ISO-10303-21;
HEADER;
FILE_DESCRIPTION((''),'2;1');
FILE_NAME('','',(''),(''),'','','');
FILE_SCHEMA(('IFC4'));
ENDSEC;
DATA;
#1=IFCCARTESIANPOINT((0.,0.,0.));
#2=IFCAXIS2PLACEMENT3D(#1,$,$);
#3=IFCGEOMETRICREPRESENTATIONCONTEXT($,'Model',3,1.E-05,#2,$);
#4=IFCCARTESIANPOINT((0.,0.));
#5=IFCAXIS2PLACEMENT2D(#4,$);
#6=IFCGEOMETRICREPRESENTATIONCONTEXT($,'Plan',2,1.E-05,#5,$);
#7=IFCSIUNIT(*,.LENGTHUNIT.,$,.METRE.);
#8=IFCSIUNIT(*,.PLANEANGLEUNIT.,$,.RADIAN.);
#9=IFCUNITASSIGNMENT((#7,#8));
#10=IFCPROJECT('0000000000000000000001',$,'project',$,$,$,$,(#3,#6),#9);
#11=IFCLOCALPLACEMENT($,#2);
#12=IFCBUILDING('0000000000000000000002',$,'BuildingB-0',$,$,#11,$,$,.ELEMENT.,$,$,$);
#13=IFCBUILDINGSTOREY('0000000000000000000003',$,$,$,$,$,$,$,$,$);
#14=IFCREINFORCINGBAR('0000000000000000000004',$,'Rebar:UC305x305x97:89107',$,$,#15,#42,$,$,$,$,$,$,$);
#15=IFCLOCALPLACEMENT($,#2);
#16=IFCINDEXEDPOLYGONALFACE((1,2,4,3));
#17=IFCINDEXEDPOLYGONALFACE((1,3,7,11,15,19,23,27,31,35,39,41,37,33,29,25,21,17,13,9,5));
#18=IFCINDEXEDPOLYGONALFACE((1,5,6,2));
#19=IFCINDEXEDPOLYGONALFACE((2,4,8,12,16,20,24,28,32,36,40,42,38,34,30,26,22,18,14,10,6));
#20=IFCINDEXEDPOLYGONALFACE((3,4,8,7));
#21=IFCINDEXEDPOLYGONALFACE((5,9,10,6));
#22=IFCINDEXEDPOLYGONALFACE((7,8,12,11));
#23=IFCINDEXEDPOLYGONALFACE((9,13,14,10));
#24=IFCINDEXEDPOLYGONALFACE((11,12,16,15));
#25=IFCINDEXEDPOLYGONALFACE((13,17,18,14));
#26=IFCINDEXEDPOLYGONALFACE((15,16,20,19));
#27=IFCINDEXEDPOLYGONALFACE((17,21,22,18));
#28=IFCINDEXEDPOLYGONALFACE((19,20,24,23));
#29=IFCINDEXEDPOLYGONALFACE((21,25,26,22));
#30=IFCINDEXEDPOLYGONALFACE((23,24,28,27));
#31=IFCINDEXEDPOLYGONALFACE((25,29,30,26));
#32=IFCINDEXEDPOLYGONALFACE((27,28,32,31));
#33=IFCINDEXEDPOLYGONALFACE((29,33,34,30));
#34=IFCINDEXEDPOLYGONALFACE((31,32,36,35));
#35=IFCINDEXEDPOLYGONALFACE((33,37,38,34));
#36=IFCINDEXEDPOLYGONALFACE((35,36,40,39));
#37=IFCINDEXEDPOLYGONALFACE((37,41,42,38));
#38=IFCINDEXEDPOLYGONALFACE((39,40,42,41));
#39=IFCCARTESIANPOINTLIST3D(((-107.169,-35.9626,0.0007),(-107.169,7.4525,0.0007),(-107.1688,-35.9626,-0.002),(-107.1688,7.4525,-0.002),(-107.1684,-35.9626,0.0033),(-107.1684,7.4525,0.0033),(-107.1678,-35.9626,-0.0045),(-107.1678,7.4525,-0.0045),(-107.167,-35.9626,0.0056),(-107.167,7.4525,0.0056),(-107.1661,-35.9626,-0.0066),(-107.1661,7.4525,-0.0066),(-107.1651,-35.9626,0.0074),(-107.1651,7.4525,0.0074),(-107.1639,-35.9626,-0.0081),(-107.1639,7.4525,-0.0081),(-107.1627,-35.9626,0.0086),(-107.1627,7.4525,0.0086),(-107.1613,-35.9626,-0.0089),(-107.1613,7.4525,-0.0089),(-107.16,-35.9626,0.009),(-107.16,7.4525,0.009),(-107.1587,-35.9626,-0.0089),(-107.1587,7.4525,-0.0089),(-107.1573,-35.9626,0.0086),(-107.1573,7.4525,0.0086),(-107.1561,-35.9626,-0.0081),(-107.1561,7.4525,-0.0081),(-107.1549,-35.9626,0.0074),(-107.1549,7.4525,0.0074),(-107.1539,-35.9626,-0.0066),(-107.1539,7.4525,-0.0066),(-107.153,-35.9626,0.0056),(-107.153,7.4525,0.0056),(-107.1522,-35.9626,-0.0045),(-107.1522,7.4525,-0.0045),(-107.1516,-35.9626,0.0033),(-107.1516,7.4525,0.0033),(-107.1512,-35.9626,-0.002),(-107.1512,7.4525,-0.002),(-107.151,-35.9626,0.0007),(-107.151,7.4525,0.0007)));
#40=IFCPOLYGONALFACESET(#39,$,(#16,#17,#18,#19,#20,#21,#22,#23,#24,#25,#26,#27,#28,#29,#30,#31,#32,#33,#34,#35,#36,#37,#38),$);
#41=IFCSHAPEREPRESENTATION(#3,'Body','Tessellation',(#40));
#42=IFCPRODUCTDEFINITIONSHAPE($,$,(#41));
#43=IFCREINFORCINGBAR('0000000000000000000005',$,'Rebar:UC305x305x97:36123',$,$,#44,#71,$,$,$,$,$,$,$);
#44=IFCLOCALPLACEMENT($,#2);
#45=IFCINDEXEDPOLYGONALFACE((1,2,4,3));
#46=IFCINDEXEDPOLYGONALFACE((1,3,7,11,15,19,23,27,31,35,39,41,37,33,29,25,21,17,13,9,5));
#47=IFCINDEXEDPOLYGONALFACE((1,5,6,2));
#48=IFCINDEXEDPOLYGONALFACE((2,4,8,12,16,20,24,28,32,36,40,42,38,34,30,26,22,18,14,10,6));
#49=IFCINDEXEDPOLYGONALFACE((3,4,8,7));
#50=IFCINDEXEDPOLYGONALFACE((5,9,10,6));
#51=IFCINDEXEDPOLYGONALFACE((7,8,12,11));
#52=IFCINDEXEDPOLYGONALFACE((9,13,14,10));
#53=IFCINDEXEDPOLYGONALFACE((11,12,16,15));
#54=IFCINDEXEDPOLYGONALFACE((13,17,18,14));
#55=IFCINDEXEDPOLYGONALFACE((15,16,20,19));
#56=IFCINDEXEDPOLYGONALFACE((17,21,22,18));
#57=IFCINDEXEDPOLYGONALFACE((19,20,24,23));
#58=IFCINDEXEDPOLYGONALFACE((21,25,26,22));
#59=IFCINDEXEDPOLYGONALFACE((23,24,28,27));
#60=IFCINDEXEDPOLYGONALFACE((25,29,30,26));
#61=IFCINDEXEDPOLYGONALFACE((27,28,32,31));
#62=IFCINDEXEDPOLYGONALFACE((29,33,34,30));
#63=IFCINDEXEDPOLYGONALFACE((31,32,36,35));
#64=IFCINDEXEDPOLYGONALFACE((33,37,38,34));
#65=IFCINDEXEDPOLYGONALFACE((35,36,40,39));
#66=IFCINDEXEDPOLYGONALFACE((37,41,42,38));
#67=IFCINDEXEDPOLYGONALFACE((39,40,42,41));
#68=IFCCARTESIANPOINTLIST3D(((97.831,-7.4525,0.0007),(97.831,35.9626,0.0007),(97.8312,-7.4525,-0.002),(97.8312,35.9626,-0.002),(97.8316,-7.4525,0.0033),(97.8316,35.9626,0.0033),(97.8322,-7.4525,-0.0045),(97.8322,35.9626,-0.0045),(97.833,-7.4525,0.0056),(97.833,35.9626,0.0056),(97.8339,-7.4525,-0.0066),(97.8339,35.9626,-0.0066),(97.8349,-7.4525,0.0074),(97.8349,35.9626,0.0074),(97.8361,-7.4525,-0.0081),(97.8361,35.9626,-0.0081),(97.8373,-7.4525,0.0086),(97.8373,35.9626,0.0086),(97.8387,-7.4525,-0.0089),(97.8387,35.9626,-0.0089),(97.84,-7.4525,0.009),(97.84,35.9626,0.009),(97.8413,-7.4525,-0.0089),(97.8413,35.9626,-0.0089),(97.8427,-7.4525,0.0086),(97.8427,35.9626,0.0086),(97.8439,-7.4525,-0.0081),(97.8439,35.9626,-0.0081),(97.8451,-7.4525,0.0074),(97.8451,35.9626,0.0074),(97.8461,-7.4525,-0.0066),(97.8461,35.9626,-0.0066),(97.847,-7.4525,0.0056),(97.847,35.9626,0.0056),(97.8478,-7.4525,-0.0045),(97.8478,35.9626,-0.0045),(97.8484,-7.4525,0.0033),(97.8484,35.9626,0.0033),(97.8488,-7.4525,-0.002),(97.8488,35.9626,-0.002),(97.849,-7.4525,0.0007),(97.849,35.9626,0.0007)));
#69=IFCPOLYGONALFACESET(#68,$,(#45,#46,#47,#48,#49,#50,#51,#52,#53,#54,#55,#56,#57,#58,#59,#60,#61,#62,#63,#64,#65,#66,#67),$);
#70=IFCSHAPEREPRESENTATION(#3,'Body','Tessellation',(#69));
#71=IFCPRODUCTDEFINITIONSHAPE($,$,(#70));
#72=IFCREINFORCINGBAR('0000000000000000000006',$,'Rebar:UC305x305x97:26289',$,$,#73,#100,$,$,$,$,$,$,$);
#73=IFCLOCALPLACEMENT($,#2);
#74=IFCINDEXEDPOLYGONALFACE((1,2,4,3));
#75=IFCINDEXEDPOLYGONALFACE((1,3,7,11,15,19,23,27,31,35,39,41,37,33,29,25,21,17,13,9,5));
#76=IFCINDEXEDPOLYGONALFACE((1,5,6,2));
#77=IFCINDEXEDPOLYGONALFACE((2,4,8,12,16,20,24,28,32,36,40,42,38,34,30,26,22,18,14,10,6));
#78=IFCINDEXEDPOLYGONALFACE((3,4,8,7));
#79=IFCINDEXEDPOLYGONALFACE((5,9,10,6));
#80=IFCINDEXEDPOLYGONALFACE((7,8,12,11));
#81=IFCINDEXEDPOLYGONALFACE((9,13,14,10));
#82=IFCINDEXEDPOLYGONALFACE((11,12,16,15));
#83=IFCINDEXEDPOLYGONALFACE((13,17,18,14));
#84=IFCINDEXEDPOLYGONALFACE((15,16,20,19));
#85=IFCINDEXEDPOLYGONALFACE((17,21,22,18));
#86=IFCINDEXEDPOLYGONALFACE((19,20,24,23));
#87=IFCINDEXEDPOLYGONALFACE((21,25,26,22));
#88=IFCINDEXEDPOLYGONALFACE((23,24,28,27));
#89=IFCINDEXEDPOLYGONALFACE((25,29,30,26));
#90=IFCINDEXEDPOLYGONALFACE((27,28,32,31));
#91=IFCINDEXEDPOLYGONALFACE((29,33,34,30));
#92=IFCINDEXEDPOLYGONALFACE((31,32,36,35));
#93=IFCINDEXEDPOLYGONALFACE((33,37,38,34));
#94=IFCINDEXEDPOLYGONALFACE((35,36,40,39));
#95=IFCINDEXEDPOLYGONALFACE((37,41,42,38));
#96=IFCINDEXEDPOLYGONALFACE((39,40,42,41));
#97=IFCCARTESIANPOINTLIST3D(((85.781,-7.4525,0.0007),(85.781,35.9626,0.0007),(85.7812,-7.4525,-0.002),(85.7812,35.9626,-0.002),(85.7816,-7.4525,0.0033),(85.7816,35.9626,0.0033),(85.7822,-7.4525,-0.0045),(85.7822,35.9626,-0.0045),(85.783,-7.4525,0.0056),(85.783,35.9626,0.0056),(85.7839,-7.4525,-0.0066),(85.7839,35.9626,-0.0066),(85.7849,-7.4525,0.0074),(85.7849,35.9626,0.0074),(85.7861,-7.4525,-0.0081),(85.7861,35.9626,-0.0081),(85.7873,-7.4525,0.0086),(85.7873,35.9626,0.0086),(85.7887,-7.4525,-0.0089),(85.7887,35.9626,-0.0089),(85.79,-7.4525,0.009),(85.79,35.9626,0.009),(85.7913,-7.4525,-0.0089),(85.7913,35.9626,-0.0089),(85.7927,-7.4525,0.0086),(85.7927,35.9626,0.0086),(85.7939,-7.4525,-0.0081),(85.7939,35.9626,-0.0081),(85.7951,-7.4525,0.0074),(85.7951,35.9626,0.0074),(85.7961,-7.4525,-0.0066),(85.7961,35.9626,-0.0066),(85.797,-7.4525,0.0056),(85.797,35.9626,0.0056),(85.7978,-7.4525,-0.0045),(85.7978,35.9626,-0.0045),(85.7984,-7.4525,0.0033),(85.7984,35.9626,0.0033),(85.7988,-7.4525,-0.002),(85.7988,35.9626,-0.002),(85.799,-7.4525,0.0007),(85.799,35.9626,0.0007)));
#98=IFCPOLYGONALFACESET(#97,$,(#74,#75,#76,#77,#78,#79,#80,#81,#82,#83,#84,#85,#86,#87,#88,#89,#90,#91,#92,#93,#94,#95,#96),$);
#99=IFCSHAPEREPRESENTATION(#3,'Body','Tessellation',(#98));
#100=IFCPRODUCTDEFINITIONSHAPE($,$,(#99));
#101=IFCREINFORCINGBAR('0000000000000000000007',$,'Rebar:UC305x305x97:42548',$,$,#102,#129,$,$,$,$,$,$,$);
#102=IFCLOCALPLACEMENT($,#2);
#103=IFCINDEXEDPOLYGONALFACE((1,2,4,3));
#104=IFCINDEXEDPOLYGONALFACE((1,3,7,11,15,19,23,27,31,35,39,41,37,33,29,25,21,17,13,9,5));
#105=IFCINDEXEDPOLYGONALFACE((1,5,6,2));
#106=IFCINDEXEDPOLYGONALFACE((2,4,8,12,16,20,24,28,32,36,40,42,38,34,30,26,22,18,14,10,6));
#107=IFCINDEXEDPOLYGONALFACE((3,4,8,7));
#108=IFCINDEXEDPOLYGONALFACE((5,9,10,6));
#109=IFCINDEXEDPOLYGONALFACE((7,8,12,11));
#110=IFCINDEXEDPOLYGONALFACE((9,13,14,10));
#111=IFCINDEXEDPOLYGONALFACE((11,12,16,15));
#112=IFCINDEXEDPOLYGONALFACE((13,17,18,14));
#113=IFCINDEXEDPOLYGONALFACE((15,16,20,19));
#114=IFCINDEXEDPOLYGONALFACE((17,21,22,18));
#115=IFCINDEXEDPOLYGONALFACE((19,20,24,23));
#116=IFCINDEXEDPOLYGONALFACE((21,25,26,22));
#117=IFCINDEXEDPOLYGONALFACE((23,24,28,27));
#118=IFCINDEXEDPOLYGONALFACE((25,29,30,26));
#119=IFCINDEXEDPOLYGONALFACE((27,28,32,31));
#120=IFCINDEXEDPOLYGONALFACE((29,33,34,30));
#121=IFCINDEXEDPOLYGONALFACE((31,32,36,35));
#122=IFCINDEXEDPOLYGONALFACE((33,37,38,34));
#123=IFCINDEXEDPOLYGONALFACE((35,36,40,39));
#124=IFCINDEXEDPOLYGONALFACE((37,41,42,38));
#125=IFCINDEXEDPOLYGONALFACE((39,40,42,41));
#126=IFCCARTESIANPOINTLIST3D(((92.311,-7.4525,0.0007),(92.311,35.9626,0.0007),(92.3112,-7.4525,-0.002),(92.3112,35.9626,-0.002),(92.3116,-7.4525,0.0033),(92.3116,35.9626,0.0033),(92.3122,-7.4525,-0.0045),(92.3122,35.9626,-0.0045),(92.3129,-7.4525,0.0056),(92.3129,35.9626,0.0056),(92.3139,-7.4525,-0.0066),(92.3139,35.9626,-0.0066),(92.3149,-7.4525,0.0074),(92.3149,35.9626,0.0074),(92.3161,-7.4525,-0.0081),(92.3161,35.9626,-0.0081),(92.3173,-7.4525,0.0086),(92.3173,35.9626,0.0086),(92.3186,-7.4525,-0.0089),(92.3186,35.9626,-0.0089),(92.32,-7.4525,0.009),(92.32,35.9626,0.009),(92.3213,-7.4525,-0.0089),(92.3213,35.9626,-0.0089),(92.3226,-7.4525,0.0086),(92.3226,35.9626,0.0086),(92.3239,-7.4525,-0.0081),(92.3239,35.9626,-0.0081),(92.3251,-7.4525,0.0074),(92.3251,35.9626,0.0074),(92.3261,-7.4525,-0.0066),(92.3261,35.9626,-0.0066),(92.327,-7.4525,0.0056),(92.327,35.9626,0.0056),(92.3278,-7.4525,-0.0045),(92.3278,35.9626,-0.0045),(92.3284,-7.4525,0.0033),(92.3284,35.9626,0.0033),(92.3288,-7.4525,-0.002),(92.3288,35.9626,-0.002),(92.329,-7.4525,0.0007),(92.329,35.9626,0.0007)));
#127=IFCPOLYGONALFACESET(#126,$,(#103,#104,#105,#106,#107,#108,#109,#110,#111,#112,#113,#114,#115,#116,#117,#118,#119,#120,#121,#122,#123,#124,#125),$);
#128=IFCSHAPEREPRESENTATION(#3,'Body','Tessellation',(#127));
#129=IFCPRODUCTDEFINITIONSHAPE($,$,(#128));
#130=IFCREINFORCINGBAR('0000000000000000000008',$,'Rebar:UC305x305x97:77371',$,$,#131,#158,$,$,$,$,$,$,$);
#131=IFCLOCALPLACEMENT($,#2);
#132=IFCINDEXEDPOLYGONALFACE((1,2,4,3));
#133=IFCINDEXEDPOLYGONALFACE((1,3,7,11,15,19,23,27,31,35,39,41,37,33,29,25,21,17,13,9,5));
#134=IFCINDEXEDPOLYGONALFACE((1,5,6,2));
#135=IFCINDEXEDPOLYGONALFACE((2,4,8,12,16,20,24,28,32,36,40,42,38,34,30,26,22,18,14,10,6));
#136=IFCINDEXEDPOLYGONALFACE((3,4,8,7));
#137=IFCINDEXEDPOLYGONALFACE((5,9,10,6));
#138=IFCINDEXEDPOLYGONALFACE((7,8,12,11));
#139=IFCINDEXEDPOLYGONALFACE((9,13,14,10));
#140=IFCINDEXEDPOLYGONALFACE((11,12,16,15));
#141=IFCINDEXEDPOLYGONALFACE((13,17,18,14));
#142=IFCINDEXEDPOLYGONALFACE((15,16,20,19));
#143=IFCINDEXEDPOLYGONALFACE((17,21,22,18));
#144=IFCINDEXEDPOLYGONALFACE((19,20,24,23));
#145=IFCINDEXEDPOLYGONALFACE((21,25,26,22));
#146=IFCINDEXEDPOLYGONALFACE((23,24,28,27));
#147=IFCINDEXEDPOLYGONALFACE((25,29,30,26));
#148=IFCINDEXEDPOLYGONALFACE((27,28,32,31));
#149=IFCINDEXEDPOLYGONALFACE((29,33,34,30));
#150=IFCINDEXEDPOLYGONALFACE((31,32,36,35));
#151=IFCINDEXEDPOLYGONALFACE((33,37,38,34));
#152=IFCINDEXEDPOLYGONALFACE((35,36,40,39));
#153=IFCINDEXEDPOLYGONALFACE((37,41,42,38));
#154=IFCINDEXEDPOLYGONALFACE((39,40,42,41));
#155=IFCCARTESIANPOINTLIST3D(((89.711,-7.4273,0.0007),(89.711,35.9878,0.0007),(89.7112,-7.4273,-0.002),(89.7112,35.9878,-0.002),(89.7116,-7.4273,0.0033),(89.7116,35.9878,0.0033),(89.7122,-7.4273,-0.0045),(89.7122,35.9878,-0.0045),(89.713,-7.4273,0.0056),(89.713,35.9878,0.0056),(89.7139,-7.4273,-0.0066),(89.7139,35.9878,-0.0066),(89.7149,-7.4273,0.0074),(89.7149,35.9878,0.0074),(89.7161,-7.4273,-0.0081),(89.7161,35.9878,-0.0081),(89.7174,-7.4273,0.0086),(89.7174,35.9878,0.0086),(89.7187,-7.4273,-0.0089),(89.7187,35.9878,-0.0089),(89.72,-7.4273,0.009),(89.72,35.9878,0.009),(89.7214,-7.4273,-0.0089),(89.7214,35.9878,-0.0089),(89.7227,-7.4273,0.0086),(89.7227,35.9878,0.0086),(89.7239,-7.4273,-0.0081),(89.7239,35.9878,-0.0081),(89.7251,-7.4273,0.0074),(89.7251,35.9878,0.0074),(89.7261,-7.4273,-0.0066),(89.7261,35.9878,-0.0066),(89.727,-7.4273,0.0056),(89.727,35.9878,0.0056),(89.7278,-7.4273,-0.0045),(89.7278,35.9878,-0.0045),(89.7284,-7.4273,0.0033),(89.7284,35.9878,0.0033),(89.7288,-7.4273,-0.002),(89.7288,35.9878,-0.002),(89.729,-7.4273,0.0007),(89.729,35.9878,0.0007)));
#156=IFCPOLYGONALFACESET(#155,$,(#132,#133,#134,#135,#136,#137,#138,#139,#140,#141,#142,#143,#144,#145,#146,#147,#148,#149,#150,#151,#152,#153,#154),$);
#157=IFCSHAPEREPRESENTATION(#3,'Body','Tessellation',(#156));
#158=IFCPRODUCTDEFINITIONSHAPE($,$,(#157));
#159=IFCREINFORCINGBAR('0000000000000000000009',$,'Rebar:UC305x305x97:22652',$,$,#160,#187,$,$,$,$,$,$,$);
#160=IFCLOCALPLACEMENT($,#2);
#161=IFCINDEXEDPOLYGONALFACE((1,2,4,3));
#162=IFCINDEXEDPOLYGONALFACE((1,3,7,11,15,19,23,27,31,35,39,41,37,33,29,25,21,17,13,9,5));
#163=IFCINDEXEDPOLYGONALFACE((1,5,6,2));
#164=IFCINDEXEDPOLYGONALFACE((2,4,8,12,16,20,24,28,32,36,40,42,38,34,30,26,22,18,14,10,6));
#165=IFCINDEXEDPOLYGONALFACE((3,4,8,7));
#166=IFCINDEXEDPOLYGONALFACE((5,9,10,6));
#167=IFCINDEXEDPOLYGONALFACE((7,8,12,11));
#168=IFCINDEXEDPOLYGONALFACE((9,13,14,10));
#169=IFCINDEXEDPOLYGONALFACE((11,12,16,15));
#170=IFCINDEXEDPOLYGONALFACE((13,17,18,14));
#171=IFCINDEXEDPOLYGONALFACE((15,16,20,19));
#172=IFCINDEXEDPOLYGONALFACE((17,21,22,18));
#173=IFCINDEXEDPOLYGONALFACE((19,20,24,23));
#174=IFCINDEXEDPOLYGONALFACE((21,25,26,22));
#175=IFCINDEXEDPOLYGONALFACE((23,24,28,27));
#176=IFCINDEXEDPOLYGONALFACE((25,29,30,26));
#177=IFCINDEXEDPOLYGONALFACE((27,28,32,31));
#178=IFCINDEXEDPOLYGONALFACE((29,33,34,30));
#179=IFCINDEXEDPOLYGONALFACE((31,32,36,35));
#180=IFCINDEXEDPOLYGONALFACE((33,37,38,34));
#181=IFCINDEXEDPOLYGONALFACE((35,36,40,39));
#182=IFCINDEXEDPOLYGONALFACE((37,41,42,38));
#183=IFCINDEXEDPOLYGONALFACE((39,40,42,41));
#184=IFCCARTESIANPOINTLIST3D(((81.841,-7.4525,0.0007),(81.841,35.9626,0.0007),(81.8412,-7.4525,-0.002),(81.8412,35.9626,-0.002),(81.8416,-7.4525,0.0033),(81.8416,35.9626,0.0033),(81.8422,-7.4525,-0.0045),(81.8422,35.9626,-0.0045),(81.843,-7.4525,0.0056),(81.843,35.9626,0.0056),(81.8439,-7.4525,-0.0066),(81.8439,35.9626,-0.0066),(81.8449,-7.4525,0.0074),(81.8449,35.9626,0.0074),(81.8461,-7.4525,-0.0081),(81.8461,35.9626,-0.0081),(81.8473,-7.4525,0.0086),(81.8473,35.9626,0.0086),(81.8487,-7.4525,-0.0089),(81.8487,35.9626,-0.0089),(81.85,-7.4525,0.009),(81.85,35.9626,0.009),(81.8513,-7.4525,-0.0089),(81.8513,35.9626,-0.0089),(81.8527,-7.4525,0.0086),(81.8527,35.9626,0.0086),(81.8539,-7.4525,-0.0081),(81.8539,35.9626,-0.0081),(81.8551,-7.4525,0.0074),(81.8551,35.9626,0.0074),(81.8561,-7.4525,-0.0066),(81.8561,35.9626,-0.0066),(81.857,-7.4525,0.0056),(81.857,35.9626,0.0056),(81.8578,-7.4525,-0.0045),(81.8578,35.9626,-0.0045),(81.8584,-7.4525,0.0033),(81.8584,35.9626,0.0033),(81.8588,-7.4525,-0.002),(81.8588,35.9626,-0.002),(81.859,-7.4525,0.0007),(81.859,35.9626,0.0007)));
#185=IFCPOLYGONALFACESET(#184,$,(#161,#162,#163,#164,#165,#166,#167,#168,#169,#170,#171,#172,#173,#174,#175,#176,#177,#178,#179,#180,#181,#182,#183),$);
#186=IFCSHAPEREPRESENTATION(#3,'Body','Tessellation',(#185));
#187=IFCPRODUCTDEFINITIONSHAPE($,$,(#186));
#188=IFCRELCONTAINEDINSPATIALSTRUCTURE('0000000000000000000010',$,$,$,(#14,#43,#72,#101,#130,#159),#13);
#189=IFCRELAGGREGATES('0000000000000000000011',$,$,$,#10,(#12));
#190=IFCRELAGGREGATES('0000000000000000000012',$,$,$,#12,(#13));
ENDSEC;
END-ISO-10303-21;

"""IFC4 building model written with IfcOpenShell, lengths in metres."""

from ifc_helpers import new_model, entity, si_unit, origin, origin_2d, place, context, project, spatial, element, save


model = new_model("IFC4")

# Units and contexts
model_context = context("Model", 3, precision=1e-05, world=origin())
plan_context = context("Plan", 2, precision=1e-05, world=origin_2d())
ifc_project = project(units=[si_unit("LENGTHUNIT", "METRE"), si_unit("PLANEANGLEUNIT", "RADIAN")], contexts=[model_context, plan_context])

# Building, storey
building_placement = place(None, origin())
building = spatial("IfcBuilding", under=ifc_project, at=building_placement, Name="BuildingB-0", CompositionType="ELEMENT")
storey = spatial("IfcBuildingStorey", under=building)

# Reinforcing bars
element("IfcReinforcingBar", 1, inside=storey, Name="Rebar:UC305x305x97:89107", context=model_context, shape_type="SweptSolid", body=[
    entity("IfcSurfaceCurveSweptAreaSolid", entity("IfcCircleProfileDef", "AREA", None, None, 0.009), None, entity("IfcPolyline", [entity("IfcCartesianPoint", [107.16, 35.9626, 0.0]), entity("IfcCartesianPoint", [107.16, -7.4525, 0.0])]), None, None, entity("IfcPlane", entity("IfcAxis2Placement3D", entity("IfcCartesianPoint", [107.16, 35.9626, 0.0]), entity("IfcDirection", [0.0, 0.0, 1.0]), entity("IfcDirection", [1.0, 0.0, 0.0])))),
])
element("IfcReinforcingBar", 2, inside=storey, Name="Rebar:UC305x305x97:36123", context=model_context, shape_type="SweptSolid", body=[
    entity("IfcSurfaceCurveSweptAreaSolid", entity("IfcCircleProfileDef", "AREA", None, None, 0.009), None, entity("IfcPolyline", [entity("IfcCartesianPoint", [97.84, 35.9626, 0.0]), entity("IfcCartesianPoint", [97.84, -7.4525, 0.0])]), None, None, entity("IfcPlane", entity("IfcAxis2Placement3D", entity("IfcCartesianPoint", [97.84, 35.9626, 0.0]), entity("IfcDirection", [0.0, 0.0, 1.0]), entity("IfcDirection", [1.0, 0.0, 0.0])))),
])
element("IfcReinforcingBar", 3, inside=storey, Name="Rebar:UC305x305x97:26289", context=model_context, shape_type="SweptSolid", body=[
    entity("IfcSurfaceCurveSweptAreaSolid", entity("IfcCircleProfileDef", "AREA", None, None, 0.009), None, entity("IfcPolyline", [entity("IfcCartesianPoint", [85.79, 35.9626, 0.0]), entity("IfcCartesianPoint", [85.79, -7.4525, 0.0])]), None, None, entity("IfcPlane", entity("IfcAxis2Placement3D", entity("IfcCartesianPoint", [85.79, 35.9626, 0.0]), entity("IfcDirection", [0.0, 0.0, 1.0]), entity("IfcDirection", [1.0, 0.0, 0.0])))),
])
element("IfcReinforcingBar", 4, inside=storey, Name="Rebar:UC305x305x97:42548", context=model_context, shape_type="SweptSolid", body=[
    entity("IfcSurfaceCurveSweptAreaSolid", entity("IfcCircleProfileDef", "AREA", None, None, 0.009), None, entity("IfcPolyline", [entity("IfcCartesianPoint", [92.32, 35.9626, 0.0]), entity("IfcCartesianPoint", [92.32, -7.4525, 0.0])]), None, None, entity("IfcPlane", entity("IfcAxis2Placement3D", entity("IfcCartesianPoint", [92.32, 35.9626, 0.0]), entity("IfcDirection", [0.0, 0.0, 1.0]), entity("IfcDirection", [1.0, 0.0, 0.0])))),
])
element("IfcReinforcingBar", 5, inside=storey, Name="Rebar:UC305x305x97:77371", context=model_context, shape_type="SweptSolid", body=[
    entity("IfcSurfaceCurveSweptAreaSolid", entity("IfcCircleProfileDef", "AREA", None, None, 0.009), None, entity("IfcPolyline", [entity("IfcCartesianPoint", [89.72, 35.9878, 0.0]), entity("IfcCartesianPoint", [89.72, -7.4273, 0.0])]), None, None, entity("IfcPlane", entity("IfcAxis2Placement3D", entity("IfcCartesianPoint", [89.72, 35.9878, 0.0]), entity("IfcDirection", [0.0, 0.0, 1.0]), entity("IfcDirection", [1.0, 0.0, 0.0])))),
])
element("IfcReinforcingBar", 6, inside=storey, Name="Rebar:UC305x305x97:22652", context=model_context, shape_type="SweptSolid", body=[
    entity("IfcSurfaceCurveSweptAreaSolid", entity("IfcCircleProfileDef", "AREA", None, None, 0.009), None, entity("IfcPolyline", [entity("IfcCartesianPoint", [81.85, 35.9626, 0.0]), entity("IfcCartesianPoint", [81.85, -7.4525, 0.0])]), None, None, entity("IfcPlane", entity("IfcAxis2Placement3D", entity("IfcCartesianPoint", [81.85, 35.9626, 0.0]), entity("IfcDirection", [0.0, 0.0, 1.0]), entity("IfcDirection", [1.0, 0.0, 0.0])))),
])

save(model, "model.ifc")
